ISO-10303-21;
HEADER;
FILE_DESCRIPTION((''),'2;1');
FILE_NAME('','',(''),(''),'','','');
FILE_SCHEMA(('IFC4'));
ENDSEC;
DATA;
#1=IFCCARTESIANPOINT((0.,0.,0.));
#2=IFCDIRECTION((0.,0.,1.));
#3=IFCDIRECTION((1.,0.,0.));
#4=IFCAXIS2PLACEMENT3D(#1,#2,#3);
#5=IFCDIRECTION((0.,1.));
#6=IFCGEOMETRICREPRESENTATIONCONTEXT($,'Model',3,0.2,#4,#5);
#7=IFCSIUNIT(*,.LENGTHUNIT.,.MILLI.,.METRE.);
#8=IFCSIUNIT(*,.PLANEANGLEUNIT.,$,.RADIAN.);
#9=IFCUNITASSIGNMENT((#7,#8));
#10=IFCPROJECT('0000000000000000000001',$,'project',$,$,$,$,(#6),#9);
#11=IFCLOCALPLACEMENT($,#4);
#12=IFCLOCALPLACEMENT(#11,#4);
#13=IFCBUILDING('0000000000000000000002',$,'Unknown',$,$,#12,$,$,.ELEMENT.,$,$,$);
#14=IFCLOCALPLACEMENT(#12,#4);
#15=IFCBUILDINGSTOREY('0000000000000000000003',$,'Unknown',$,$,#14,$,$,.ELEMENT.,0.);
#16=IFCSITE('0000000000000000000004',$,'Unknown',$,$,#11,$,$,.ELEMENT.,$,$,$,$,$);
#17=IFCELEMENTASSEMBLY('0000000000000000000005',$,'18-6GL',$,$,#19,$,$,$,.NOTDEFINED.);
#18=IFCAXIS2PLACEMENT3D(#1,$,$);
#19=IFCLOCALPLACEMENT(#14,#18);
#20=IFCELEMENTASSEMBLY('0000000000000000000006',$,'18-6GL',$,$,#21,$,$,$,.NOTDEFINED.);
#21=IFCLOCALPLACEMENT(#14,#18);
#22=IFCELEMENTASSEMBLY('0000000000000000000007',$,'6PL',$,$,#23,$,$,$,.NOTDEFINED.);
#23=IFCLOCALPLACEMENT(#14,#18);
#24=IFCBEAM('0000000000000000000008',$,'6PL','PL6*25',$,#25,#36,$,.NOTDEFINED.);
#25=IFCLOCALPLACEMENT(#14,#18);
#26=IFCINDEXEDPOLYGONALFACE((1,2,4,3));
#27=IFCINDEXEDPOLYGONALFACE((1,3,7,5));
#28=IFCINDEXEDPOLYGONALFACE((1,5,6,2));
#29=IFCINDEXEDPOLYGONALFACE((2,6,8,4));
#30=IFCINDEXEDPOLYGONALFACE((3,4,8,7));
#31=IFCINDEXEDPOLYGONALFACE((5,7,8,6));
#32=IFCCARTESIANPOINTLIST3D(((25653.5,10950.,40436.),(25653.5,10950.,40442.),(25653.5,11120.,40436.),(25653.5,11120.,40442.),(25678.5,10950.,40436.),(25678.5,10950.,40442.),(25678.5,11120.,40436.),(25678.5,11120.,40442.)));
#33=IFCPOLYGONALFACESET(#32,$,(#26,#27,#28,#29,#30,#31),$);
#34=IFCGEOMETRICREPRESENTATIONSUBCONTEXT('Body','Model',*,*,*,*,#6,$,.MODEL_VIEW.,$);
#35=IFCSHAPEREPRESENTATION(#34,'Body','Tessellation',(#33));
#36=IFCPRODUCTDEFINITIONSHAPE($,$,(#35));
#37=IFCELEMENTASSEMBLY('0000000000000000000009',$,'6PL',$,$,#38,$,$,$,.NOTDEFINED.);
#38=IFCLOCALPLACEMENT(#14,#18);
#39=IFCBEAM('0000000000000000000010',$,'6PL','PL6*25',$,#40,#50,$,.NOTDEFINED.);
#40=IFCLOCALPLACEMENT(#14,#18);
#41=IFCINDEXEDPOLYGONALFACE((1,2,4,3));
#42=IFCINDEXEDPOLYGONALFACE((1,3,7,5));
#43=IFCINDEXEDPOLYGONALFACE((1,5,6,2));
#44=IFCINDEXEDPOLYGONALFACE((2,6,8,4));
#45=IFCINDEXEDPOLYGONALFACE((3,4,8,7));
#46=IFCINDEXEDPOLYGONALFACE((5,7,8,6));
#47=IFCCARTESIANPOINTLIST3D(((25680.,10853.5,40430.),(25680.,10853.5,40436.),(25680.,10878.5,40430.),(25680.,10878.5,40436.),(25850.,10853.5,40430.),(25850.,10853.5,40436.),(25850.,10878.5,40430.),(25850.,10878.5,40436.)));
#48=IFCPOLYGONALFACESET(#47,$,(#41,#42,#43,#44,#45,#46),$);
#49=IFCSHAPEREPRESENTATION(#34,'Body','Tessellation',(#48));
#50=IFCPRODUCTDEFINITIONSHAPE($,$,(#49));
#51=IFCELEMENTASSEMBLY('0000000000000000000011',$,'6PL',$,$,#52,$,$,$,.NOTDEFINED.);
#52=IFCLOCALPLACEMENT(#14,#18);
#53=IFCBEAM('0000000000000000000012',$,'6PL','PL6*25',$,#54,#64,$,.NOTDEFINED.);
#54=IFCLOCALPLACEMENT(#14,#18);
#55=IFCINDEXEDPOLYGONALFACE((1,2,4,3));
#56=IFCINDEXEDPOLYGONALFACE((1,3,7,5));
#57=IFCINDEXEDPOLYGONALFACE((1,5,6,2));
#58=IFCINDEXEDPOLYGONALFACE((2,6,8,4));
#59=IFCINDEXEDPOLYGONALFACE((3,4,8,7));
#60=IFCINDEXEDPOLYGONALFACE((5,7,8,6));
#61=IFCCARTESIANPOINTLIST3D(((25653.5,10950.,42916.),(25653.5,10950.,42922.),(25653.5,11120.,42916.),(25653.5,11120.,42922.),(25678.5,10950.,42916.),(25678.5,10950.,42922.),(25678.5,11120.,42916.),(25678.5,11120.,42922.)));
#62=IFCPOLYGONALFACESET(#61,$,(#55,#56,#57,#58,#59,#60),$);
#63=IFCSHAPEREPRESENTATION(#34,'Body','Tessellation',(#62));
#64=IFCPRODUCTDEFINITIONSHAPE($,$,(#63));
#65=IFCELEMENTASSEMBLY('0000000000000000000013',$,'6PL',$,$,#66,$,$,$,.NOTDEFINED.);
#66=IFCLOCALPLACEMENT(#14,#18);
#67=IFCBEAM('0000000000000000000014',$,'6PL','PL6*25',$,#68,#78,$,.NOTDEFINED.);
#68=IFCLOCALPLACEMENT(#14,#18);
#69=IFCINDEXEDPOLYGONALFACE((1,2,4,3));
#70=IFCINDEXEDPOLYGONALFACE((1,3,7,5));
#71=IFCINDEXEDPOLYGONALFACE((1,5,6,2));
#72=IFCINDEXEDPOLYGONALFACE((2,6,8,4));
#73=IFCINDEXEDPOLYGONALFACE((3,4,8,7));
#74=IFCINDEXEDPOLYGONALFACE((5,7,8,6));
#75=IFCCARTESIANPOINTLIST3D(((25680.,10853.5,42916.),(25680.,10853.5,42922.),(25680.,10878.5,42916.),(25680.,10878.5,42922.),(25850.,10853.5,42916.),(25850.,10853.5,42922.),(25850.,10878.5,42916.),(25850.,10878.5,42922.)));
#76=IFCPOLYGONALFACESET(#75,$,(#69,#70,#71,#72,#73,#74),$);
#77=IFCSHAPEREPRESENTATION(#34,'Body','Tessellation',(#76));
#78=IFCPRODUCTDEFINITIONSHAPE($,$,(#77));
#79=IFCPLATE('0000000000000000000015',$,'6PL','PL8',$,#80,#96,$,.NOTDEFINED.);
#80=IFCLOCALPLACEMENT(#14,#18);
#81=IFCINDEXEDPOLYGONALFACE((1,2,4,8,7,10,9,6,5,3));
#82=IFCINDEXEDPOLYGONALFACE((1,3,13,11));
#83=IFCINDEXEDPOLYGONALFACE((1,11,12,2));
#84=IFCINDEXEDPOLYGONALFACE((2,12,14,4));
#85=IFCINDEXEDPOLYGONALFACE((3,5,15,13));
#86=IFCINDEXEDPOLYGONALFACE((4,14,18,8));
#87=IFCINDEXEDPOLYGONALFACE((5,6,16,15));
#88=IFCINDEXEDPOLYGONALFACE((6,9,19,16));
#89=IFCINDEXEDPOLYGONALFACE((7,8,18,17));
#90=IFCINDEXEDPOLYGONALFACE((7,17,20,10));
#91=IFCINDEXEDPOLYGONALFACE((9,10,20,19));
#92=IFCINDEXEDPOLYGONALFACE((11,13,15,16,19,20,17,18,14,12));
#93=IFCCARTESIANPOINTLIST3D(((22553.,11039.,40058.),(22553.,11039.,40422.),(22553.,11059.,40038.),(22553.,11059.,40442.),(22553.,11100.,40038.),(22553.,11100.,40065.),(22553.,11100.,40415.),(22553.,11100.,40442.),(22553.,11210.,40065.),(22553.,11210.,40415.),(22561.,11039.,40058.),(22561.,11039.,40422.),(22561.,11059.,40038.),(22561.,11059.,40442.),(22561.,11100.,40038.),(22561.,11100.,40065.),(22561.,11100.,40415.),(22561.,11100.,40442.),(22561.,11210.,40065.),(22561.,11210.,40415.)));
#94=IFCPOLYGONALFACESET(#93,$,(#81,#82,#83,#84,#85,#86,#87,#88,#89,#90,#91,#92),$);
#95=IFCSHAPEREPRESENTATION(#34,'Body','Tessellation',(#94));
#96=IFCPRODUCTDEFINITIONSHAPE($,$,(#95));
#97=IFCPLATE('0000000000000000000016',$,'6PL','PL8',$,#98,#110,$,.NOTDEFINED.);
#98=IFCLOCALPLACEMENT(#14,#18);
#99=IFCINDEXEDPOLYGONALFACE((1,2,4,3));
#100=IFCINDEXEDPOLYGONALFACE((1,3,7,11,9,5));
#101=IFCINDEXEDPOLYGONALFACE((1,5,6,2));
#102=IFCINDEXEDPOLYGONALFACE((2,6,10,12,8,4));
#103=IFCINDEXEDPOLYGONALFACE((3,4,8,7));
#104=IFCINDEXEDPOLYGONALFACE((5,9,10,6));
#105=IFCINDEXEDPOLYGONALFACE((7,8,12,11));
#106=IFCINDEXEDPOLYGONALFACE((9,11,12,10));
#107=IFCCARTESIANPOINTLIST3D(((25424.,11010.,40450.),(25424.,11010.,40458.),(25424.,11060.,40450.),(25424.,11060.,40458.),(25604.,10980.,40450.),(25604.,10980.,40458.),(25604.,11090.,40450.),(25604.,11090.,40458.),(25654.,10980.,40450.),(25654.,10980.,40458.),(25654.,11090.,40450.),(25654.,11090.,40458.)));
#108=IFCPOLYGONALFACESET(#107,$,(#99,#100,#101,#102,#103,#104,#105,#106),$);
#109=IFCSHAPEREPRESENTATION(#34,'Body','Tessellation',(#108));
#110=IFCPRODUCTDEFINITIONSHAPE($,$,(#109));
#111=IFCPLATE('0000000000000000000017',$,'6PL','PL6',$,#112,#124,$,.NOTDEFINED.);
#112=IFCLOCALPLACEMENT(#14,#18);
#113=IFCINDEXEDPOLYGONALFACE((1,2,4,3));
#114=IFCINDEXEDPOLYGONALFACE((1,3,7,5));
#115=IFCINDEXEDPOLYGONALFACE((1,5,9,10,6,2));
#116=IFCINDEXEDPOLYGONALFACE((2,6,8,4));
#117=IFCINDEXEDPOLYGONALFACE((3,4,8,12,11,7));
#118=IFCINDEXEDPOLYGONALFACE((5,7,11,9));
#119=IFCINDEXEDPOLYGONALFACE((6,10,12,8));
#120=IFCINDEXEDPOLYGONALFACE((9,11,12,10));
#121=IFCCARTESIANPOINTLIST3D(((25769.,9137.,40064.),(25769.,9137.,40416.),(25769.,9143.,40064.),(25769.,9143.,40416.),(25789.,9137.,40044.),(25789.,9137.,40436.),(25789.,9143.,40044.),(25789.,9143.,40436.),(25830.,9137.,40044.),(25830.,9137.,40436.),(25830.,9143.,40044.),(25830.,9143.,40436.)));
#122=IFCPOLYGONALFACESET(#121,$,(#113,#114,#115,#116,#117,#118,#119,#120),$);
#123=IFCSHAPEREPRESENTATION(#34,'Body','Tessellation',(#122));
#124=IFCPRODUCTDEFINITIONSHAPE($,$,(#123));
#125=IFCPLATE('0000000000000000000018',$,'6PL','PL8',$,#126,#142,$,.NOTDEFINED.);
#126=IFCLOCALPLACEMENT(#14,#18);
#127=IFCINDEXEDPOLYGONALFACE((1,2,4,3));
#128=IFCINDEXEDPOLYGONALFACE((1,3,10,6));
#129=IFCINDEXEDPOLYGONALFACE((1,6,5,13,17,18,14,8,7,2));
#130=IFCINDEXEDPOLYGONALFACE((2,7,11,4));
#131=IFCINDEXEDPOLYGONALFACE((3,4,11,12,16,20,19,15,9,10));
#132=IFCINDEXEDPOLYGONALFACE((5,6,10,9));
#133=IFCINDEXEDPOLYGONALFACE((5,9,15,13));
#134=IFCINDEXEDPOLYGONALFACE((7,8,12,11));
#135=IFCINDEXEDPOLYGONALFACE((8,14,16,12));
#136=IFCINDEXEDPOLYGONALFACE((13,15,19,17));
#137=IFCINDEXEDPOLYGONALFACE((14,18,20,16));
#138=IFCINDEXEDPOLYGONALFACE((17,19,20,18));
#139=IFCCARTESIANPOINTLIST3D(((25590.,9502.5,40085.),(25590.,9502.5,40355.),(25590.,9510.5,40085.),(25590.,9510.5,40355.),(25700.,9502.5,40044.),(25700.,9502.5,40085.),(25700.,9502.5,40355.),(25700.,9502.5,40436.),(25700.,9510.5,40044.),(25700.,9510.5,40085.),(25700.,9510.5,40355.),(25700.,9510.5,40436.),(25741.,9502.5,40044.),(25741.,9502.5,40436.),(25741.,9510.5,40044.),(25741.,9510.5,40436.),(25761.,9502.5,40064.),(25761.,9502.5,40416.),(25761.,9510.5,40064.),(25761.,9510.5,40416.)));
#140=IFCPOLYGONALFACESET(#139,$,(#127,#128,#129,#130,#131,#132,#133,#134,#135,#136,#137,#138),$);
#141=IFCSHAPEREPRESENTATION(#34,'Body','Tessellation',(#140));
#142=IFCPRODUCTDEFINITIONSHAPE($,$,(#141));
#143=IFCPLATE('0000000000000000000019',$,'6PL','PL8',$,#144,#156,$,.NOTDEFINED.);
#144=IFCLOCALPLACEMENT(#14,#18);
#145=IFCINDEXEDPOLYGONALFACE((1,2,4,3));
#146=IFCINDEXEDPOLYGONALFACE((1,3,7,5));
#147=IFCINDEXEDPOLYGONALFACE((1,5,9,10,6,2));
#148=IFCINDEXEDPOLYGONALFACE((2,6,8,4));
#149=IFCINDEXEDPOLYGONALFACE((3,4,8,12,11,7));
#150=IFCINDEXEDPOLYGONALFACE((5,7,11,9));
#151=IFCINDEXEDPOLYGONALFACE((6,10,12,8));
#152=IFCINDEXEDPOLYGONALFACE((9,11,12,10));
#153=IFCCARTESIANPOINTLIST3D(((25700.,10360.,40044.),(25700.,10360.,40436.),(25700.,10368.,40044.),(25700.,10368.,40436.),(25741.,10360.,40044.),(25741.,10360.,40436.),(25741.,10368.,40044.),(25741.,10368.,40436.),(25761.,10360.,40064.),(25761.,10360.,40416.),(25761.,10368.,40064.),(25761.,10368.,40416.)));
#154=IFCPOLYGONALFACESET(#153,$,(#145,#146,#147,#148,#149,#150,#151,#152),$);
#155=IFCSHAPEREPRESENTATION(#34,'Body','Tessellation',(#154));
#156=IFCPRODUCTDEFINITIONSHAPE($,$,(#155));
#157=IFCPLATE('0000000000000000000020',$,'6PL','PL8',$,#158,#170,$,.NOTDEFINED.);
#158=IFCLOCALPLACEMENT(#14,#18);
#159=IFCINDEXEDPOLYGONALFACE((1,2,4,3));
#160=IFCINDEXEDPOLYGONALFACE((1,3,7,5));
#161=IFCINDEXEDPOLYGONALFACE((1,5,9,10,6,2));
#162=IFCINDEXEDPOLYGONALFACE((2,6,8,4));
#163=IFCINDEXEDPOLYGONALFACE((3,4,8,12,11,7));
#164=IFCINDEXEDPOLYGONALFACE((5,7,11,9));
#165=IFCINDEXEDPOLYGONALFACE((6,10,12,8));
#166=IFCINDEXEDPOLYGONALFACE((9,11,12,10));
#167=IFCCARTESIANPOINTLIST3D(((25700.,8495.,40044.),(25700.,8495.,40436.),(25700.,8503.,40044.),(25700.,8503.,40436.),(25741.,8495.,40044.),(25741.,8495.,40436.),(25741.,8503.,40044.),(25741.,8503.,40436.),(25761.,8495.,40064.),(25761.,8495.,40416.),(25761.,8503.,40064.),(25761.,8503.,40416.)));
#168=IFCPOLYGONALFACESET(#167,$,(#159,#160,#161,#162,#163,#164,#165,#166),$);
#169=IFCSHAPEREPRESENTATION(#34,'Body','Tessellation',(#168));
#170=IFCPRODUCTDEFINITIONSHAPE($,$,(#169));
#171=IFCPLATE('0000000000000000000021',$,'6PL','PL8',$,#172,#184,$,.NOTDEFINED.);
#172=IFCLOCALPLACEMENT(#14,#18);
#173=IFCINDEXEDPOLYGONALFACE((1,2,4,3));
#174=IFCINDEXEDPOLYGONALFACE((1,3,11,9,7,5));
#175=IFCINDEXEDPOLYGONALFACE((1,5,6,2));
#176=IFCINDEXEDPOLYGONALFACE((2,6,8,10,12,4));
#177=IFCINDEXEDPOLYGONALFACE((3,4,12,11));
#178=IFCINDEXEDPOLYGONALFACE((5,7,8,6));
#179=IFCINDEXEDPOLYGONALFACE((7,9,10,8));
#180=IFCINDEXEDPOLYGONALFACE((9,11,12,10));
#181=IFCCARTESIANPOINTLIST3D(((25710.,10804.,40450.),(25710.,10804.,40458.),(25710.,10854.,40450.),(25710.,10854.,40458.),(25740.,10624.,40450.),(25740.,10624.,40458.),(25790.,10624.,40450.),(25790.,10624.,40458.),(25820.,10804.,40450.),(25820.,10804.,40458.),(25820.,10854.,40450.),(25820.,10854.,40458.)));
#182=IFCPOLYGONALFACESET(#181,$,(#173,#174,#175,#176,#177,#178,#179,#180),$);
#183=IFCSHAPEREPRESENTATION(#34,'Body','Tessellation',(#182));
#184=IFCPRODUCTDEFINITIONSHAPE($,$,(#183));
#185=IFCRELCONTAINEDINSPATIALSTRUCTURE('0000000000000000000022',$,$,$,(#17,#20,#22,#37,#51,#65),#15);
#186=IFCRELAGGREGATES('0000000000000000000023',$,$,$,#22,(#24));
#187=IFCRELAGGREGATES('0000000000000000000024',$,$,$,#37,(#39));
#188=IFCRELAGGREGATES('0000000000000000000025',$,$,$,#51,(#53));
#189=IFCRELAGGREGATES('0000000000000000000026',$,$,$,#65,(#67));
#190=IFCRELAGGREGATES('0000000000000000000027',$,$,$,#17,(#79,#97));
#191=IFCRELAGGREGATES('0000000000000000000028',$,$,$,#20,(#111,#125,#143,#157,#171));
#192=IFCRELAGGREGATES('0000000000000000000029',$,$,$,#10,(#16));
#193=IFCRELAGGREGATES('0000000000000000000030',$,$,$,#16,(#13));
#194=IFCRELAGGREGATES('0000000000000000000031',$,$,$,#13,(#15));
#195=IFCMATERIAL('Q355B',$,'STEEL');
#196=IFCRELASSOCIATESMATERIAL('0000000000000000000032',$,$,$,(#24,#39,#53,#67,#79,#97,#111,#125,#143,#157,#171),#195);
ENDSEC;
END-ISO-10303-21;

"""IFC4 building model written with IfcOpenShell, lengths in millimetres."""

from ifc_helpers import new_model, si_unit, direction, frame, origin_with_axes, place, context, subcontext, project, spatial, line, indexed_curve, outline, extrude, material, element, aggregate, save


model = new_model("IFC4")

# Units and contexts
model_context = context("Model", 3, precision=0.2, world=origin_with_axes(), true_north=direction((0.0, 1.0)))
body_context = subcontext(model_context, "Body", "Model", "MODEL_VIEW")
ifc_project = project(units=[si_unit("LENGTHUNIT", "METRE", prefix="MILLI"), si_unit("PLANEANGLEUNIT", "RADIAN")], contexts=[model_context])

# Site, building, storey
site_placement = place(None, origin_with_axes())
site = spatial("IfcSite", under=ifc_project, at=site_placement, Name="Unknown", CompositionType="ELEMENT")
building_placement = place(site_placement, origin_with_axes())
building = spatial("IfcBuilding", under=site, at=building_placement, Name="Unknown", CompositionType="ELEMENT")
storey_placement = place(building_placement, origin_with_axes())
storey = spatial("IfcBuildingStorey", under=building, at=storey_placement, Name="Unknown", CompositionType="ELEMENT", Elevation=0.0)

# Element assembly
assembly_1_placement = place(storey_placement, frame((21150.0, 11035.0, 40240.0), z_axis=(0.0, -1.0, 0.0), x_axis=(1.0, 0.0, 0.0)))
assembly_1 = element("IfcElementAssembly", 1, at=assembly_1_placement, inside=storey, Name="18-6GL", PredefinedType="NOTDEFINED")

# Element assembly
assembly_2_placement = place(storey_placement, frame((25765.0, 10900.0, 40240.0), z_axis=(-1.0, 0.0, 0.0), x_axis=(0.0, -1.0, 0.0)))
assembly_2 = element("IfcElementAssembly", 2, at=assembly_2_placement, inside=storey, Name="18-6GL", PredefinedType="NOTDEFINED")
ifc_material_1 = material(Name="Q355B", Category="STEEL")

# Element assemblies, beams
assembly_3_placement = place(storey_placement, frame((25666.0, 11120.0, 40439.0), z_axis=(0.0, 0.0, -1.0), x_axis=(0.0, -1.0, 0.0)))
assembly_3 = element("IfcElementAssembly", 3, at=assembly_3_placement, inside=storey, Name="6PL", PredefinedType="NOTDEFINED")
beam_1_placement = place(assembly_3_placement, origin_with_axes())
beam_1 = element("IfcBeam", 4, at=beam_1_placement, material=ifc_material_1, Name="6PL", Description="PL6*25", PredefinedType="NOTDEFINED", context=body_context, shape_type="SolidModel", body=[
    extrude(outline(indexed_curve([(-3.0, -12.5), (3.0, -12.5), (3.0, 12.5), (-3.0, 12.5)], segments=[line(1, 2, 3, 4, 1)])), frame((0.0, 0.0, 0.0), z_axis=(-1.0, 0.0, 0.0), x_axis=(0.0, 0.0, 1.0)), (0.0, 0.0, -1.0), 170.0),
])
aggregate(assembly_3, [beam_1])
assembly_4_placement = place(storey_placement, frame((25680.0, 10866.0, 40433.0), z_axis=(0.0, 0.0, -1.0), x_axis=(1.0, 0.0, 0.0)))
assembly_4 = element("IfcElementAssembly", 5, at=assembly_4_placement, inside=storey, Name="6PL", PredefinedType="NOTDEFINED")
beam_2_placement = place(assembly_4_placement, origin_with_axes())
beam_2 = element("IfcBeam", 6, at=beam_2_placement, material=ifc_material_1, Name="6PL", Description="PL6*25", PredefinedType="NOTDEFINED", context=body_context, shape_type="SolidModel", body=[
    extrude(outline(indexed_curve([(-3.0, -12.5), (3.0, -12.5), (3.0, 12.5), (-3.0, 12.5)], segments=[line(1, 2, 3, 4, 1)])), frame((0.0, 0.0, 0.0), z_axis=(-1.0, 0.0, 0.0), x_axis=(0.0, 0.0, 1.0)), (0.0, 0.0, -1.0), 170.0),
])
aggregate(assembly_4, [beam_2])
assembly_5_placement = place(storey_placement, frame((25666.0, 11120.0, 42919.0), z_axis=(0.0, 0.0, -1.0), x_axis=(0.0, -1.0, 0.0)))
assembly_5 = element("IfcElementAssembly", 7, at=assembly_5_placement, inside=storey, Name="6PL", PredefinedType="NOTDEFINED")
beam_3_placement = place(assembly_5_placement, origin_with_axes())
beam_3 = element("IfcBeam", 8, at=beam_3_placement, material=ifc_material_1, Name="6PL", Description="PL6*25", PredefinedType="NOTDEFINED", context=body_context, shape_type="SolidModel", body=[
    extrude(outline(indexed_curve([(-3.0, -12.5), (3.0, -12.5), (3.0, 12.5), (-3.0, 12.5)], segments=[line(1, 2, 3, 4, 1)])), frame((0.0, 0.0, 0.0), z_axis=(-1.0, 0.0, 0.0), x_axis=(0.0, 0.0, 1.0)), (0.0, 0.0, -1.0), 170.0),
])
aggregate(assembly_5, [beam_3])
assembly_6_placement = place(storey_placement, frame((25680.0, 10866.0, 42919.0), z_axis=(0.0, 0.0, -1.0), x_axis=(1.0, 0.0, 0.0)))
assembly_6 = element("IfcElementAssembly", 9, at=assembly_6_placement, inside=storey, Name="6PL", PredefinedType="NOTDEFINED")
beam_4_placement = place(assembly_6_placement, origin_with_axes())
beam_4 = element("IfcBeam", 10, at=beam_4_placement, material=ifc_material_1, Name="6PL", Description="PL6*25", PredefinedType="NOTDEFINED", context=body_context, shape_type="SolidModel", body=[
    extrude(outline(indexed_curve([(-3.0, -12.5), (3.0, -12.5), (3.0, 12.5), (-3.0, 12.5)], segments=[line(1, 2, 3, 4, 1)])), frame((0.0, 0.0, 0.0), z_axis=(-1.0, 0.0, 0.0), x_axis=(0.0, 0.0, 1.0)), (0.0, 0.0, -1.0), 170.0),
])
aggregate(assembly_6, [beam_4])

# Plates
plate_1_placement = place(assembly_1_placement, frame((1407.0, -182.0, -4.0), z_axis=(1.0, 0.0, 0.0), x_axis=(0.0, -0.707107, -0.707107)))
plate_1 = element("IfcPlate", 11, at=plate_1_placement, material=ifc_material_1, Name="6PL", Description="PL8", PredefinedType="NOTDEFINED", context=body_context, shape_type="SolidModel", body=[
    extrude(outline(indexed_curve([(0.0, 0.0), (28.3, 0.0), (57.3, 29.0), (38.2, 48.1), (116.0, 125.9), (-131.5, 373.4), (-209.3, 295.6), (-228.4, 314.7), (-257.4, 285.7), (-257.4, 257.4)], segments=[line(1, 2, 3, 4, 5, 6, 7, 8, 9, 10, 1)])), frame((0.0, 0.0, 4.0), z_axis=(0.0, 0.0, 1.0), x_axis=(1.0, 0.0, 0.0)), (0.0, 0.0, -1.0), 8.0),
])
plate_2_placement = place(assembly_1_placement, frame((4454.0, 214.0, 55.0), z_axis=(0.0, 1.0, 0.0), x_axis=(1.0, 0.0, 0.0)))
plate_2 = element("IfcPlate", 12, at=plate_2_placement, material=ifc_material_1, Name="6PL", Description="PL8", PredefinedType="NOTDEFINED", context=body_context, shape_type="SolidModel", body=[
    extrude(outline(indexed_curve([(0.0, 0.0), (50.0, 0.0), (50.0, 110.0), (0.0, 110.0), (-180.0, 80.0), (-180.0, 30.0)], segments=[line(1, 2, 3, 4, 5, 6, 1)])), frame((0.0, 0.0, 4.0), z_axis=(0.0, 0.0, 1.0), x_axis=(1.0, 0.0, 0.0)), (0.0, 0.0, -1.0), 8.0),
])
aggregate(assembly_1, [plate_1, plate_2])
plate_3_placement = place(assembly_2_placement, frame((1760.0, -196.0, -65.0), z_axis=(-1.0, 0.0, 0.0), x_axis=(0.0, 0.0, 1.0)))
plate_3 = element("IfcPlate", 13, at=plate_3_placement, material=ifc_material_1, Name="6PL", Description="PL6", PredefinedType="NOTDEFINED", context=body_context, shape_type="SolidModel", body=[
    extrude(outline(indexed_curve([(0.0, 0.0), (41.0, 0.0), (61.0, 20.0), (61.0, 372.0), (41.0, 392.0), (0.0, 392.0)], segments=[line(1, 2, 3, 4, 5, 6, 1)])), frame((0.0, 0.0, 3.0), z_axis=(0.0, 0.0, 1.0), x_axis=(1.0, 0.0, 0.0)), (0.0, 0.0, -1.0), 6.0),
])
plate_4_placement = place(assembly_2_placement, frame((1393.5, -176.0, 4.0), z_axis=(-1.0, 0.0, 0.0), x_axis=(0.0, -0.707107, 0.707107)))
plate_4 = element("IfcPlate", 14, at=plate_4_placement, material=ifc_material_1, Name="6PL", Description="PL8", PredefinedType="NOTDEFINED", context=body_context, shape_type="SolidModel", body=[
    extrude(outline(indexed_curve([(0.0, 0.0), (28.3, 0.0), (57.3, 29.0), (28.3, 58.0), (106.1, 135.8), (-84.9, 326.7), (-162.6, 248.9), (-219.9, 306.2), (-248.9, 277.2), (-248.9, 248.9)], segments=[line(1, 2, 3, 4, 5, 6, 7, 8, 9, 10, 1)])), frame((0.0, 0.0, 4.0), z_axis=(0.0, 0.0, 1.0), x_axis=(1.0, 0.0, 0.0)), (0.0, 0.0, -1.0), 8.0),
])
plate_5_placement = place(assembly_2_placement, frame((536.0, -196.0, 4.0), z_axis=(-1.0, 0.0, 0.0), x_axis=(0.0, 0.0, 1.0)))
plate_5 = element("IfcPlate", 15, at=plate_5_placement, material=ifc_material_1, Name="6PL", Description="PL8", PredefinedType="NOTDEFINED", context=body_context, shape_type="SolidModel", body=[
    extrude(outline(indexed_curve([(0.0, 20.0), (20.0, 0.0), (61.0, 0.0), (61.0, 392.0), (20.0, 392.0), (0.0, 372.0)], segments=[line(1, 2, 3, 4, 5, 6, 1)])), frame((0.0, 0.0, 4.0), z_axis=(0.0, 0.0, 1.0), x_axis=(1.0, 0.0, 0.0)), (0.0, 0.0, -1.0), 8.0),
])
plate_6_placement = place(assembly_2_placement, frame((2401.0, -196.0, 4.0), z_axis=(-1.0, 0.0, 0.0), x_axis=(0.0, 0.0, 1.0)))
plate_6 = element("IfcPlate", 16, at=plate_6_placement, material=ifc_material_1, Name="6PL", Description="PL8", PredefinedType="NOTDEFINED", context=body_context, shape_type="SolidModel", body=[
    extrude(outline(indexed_curve([(0.0, 20.0), (20.0, 0.0), (61.0, 0.0), (61.0, 392.0), (20.0, 392.0), (0.0, 372.0)], segments=[line(1, 2, 3, 4, 5, 6, 1)])), frame((0.0, 0.0, 4.0), z_axis=(0.0, 0.0, 1.0), x_axis=(1.0, 0.0, 0.0)), (0.0, 0.0, -1.0), 8.0),
])
plate_7_placement = place(assembly_2_placement, frame((96.0, 214.0, -55.0), z_axis=(0.0, 1.0, 0.0), x_axis=(-1.0, 0.0, 0.0)))
plate_7 = element("IfcPlate", 17, at=plate_7_placement, material=ifc_material_1, Name="6PL", Description="PL8", PredefinedType="NOTDEFINED", context=body_context, shape_type="SolidModel", body=[
    extrude(outline(indexed_curve([(0.0, 0.0), (50.0, 0.0), (50.0, 110.0), (0.0, 110.0), (-180.0, 80.0), (-180.0, 30.0)], segments=[line(1, 2, 3, 4, 5, 6, 1)])), frame((0.0, 0.0, 4.0), z_axis=(0.0, 0.0, 1.0), x_axis=(1.0, 0.0, 0.0)), (0.0, 0.0, -1.0), 8.0),
])

aggregate(assembly_2, [plate_3, plate_4, plate_5, plate_6, plate_7])

save(model, "model.ifc")
